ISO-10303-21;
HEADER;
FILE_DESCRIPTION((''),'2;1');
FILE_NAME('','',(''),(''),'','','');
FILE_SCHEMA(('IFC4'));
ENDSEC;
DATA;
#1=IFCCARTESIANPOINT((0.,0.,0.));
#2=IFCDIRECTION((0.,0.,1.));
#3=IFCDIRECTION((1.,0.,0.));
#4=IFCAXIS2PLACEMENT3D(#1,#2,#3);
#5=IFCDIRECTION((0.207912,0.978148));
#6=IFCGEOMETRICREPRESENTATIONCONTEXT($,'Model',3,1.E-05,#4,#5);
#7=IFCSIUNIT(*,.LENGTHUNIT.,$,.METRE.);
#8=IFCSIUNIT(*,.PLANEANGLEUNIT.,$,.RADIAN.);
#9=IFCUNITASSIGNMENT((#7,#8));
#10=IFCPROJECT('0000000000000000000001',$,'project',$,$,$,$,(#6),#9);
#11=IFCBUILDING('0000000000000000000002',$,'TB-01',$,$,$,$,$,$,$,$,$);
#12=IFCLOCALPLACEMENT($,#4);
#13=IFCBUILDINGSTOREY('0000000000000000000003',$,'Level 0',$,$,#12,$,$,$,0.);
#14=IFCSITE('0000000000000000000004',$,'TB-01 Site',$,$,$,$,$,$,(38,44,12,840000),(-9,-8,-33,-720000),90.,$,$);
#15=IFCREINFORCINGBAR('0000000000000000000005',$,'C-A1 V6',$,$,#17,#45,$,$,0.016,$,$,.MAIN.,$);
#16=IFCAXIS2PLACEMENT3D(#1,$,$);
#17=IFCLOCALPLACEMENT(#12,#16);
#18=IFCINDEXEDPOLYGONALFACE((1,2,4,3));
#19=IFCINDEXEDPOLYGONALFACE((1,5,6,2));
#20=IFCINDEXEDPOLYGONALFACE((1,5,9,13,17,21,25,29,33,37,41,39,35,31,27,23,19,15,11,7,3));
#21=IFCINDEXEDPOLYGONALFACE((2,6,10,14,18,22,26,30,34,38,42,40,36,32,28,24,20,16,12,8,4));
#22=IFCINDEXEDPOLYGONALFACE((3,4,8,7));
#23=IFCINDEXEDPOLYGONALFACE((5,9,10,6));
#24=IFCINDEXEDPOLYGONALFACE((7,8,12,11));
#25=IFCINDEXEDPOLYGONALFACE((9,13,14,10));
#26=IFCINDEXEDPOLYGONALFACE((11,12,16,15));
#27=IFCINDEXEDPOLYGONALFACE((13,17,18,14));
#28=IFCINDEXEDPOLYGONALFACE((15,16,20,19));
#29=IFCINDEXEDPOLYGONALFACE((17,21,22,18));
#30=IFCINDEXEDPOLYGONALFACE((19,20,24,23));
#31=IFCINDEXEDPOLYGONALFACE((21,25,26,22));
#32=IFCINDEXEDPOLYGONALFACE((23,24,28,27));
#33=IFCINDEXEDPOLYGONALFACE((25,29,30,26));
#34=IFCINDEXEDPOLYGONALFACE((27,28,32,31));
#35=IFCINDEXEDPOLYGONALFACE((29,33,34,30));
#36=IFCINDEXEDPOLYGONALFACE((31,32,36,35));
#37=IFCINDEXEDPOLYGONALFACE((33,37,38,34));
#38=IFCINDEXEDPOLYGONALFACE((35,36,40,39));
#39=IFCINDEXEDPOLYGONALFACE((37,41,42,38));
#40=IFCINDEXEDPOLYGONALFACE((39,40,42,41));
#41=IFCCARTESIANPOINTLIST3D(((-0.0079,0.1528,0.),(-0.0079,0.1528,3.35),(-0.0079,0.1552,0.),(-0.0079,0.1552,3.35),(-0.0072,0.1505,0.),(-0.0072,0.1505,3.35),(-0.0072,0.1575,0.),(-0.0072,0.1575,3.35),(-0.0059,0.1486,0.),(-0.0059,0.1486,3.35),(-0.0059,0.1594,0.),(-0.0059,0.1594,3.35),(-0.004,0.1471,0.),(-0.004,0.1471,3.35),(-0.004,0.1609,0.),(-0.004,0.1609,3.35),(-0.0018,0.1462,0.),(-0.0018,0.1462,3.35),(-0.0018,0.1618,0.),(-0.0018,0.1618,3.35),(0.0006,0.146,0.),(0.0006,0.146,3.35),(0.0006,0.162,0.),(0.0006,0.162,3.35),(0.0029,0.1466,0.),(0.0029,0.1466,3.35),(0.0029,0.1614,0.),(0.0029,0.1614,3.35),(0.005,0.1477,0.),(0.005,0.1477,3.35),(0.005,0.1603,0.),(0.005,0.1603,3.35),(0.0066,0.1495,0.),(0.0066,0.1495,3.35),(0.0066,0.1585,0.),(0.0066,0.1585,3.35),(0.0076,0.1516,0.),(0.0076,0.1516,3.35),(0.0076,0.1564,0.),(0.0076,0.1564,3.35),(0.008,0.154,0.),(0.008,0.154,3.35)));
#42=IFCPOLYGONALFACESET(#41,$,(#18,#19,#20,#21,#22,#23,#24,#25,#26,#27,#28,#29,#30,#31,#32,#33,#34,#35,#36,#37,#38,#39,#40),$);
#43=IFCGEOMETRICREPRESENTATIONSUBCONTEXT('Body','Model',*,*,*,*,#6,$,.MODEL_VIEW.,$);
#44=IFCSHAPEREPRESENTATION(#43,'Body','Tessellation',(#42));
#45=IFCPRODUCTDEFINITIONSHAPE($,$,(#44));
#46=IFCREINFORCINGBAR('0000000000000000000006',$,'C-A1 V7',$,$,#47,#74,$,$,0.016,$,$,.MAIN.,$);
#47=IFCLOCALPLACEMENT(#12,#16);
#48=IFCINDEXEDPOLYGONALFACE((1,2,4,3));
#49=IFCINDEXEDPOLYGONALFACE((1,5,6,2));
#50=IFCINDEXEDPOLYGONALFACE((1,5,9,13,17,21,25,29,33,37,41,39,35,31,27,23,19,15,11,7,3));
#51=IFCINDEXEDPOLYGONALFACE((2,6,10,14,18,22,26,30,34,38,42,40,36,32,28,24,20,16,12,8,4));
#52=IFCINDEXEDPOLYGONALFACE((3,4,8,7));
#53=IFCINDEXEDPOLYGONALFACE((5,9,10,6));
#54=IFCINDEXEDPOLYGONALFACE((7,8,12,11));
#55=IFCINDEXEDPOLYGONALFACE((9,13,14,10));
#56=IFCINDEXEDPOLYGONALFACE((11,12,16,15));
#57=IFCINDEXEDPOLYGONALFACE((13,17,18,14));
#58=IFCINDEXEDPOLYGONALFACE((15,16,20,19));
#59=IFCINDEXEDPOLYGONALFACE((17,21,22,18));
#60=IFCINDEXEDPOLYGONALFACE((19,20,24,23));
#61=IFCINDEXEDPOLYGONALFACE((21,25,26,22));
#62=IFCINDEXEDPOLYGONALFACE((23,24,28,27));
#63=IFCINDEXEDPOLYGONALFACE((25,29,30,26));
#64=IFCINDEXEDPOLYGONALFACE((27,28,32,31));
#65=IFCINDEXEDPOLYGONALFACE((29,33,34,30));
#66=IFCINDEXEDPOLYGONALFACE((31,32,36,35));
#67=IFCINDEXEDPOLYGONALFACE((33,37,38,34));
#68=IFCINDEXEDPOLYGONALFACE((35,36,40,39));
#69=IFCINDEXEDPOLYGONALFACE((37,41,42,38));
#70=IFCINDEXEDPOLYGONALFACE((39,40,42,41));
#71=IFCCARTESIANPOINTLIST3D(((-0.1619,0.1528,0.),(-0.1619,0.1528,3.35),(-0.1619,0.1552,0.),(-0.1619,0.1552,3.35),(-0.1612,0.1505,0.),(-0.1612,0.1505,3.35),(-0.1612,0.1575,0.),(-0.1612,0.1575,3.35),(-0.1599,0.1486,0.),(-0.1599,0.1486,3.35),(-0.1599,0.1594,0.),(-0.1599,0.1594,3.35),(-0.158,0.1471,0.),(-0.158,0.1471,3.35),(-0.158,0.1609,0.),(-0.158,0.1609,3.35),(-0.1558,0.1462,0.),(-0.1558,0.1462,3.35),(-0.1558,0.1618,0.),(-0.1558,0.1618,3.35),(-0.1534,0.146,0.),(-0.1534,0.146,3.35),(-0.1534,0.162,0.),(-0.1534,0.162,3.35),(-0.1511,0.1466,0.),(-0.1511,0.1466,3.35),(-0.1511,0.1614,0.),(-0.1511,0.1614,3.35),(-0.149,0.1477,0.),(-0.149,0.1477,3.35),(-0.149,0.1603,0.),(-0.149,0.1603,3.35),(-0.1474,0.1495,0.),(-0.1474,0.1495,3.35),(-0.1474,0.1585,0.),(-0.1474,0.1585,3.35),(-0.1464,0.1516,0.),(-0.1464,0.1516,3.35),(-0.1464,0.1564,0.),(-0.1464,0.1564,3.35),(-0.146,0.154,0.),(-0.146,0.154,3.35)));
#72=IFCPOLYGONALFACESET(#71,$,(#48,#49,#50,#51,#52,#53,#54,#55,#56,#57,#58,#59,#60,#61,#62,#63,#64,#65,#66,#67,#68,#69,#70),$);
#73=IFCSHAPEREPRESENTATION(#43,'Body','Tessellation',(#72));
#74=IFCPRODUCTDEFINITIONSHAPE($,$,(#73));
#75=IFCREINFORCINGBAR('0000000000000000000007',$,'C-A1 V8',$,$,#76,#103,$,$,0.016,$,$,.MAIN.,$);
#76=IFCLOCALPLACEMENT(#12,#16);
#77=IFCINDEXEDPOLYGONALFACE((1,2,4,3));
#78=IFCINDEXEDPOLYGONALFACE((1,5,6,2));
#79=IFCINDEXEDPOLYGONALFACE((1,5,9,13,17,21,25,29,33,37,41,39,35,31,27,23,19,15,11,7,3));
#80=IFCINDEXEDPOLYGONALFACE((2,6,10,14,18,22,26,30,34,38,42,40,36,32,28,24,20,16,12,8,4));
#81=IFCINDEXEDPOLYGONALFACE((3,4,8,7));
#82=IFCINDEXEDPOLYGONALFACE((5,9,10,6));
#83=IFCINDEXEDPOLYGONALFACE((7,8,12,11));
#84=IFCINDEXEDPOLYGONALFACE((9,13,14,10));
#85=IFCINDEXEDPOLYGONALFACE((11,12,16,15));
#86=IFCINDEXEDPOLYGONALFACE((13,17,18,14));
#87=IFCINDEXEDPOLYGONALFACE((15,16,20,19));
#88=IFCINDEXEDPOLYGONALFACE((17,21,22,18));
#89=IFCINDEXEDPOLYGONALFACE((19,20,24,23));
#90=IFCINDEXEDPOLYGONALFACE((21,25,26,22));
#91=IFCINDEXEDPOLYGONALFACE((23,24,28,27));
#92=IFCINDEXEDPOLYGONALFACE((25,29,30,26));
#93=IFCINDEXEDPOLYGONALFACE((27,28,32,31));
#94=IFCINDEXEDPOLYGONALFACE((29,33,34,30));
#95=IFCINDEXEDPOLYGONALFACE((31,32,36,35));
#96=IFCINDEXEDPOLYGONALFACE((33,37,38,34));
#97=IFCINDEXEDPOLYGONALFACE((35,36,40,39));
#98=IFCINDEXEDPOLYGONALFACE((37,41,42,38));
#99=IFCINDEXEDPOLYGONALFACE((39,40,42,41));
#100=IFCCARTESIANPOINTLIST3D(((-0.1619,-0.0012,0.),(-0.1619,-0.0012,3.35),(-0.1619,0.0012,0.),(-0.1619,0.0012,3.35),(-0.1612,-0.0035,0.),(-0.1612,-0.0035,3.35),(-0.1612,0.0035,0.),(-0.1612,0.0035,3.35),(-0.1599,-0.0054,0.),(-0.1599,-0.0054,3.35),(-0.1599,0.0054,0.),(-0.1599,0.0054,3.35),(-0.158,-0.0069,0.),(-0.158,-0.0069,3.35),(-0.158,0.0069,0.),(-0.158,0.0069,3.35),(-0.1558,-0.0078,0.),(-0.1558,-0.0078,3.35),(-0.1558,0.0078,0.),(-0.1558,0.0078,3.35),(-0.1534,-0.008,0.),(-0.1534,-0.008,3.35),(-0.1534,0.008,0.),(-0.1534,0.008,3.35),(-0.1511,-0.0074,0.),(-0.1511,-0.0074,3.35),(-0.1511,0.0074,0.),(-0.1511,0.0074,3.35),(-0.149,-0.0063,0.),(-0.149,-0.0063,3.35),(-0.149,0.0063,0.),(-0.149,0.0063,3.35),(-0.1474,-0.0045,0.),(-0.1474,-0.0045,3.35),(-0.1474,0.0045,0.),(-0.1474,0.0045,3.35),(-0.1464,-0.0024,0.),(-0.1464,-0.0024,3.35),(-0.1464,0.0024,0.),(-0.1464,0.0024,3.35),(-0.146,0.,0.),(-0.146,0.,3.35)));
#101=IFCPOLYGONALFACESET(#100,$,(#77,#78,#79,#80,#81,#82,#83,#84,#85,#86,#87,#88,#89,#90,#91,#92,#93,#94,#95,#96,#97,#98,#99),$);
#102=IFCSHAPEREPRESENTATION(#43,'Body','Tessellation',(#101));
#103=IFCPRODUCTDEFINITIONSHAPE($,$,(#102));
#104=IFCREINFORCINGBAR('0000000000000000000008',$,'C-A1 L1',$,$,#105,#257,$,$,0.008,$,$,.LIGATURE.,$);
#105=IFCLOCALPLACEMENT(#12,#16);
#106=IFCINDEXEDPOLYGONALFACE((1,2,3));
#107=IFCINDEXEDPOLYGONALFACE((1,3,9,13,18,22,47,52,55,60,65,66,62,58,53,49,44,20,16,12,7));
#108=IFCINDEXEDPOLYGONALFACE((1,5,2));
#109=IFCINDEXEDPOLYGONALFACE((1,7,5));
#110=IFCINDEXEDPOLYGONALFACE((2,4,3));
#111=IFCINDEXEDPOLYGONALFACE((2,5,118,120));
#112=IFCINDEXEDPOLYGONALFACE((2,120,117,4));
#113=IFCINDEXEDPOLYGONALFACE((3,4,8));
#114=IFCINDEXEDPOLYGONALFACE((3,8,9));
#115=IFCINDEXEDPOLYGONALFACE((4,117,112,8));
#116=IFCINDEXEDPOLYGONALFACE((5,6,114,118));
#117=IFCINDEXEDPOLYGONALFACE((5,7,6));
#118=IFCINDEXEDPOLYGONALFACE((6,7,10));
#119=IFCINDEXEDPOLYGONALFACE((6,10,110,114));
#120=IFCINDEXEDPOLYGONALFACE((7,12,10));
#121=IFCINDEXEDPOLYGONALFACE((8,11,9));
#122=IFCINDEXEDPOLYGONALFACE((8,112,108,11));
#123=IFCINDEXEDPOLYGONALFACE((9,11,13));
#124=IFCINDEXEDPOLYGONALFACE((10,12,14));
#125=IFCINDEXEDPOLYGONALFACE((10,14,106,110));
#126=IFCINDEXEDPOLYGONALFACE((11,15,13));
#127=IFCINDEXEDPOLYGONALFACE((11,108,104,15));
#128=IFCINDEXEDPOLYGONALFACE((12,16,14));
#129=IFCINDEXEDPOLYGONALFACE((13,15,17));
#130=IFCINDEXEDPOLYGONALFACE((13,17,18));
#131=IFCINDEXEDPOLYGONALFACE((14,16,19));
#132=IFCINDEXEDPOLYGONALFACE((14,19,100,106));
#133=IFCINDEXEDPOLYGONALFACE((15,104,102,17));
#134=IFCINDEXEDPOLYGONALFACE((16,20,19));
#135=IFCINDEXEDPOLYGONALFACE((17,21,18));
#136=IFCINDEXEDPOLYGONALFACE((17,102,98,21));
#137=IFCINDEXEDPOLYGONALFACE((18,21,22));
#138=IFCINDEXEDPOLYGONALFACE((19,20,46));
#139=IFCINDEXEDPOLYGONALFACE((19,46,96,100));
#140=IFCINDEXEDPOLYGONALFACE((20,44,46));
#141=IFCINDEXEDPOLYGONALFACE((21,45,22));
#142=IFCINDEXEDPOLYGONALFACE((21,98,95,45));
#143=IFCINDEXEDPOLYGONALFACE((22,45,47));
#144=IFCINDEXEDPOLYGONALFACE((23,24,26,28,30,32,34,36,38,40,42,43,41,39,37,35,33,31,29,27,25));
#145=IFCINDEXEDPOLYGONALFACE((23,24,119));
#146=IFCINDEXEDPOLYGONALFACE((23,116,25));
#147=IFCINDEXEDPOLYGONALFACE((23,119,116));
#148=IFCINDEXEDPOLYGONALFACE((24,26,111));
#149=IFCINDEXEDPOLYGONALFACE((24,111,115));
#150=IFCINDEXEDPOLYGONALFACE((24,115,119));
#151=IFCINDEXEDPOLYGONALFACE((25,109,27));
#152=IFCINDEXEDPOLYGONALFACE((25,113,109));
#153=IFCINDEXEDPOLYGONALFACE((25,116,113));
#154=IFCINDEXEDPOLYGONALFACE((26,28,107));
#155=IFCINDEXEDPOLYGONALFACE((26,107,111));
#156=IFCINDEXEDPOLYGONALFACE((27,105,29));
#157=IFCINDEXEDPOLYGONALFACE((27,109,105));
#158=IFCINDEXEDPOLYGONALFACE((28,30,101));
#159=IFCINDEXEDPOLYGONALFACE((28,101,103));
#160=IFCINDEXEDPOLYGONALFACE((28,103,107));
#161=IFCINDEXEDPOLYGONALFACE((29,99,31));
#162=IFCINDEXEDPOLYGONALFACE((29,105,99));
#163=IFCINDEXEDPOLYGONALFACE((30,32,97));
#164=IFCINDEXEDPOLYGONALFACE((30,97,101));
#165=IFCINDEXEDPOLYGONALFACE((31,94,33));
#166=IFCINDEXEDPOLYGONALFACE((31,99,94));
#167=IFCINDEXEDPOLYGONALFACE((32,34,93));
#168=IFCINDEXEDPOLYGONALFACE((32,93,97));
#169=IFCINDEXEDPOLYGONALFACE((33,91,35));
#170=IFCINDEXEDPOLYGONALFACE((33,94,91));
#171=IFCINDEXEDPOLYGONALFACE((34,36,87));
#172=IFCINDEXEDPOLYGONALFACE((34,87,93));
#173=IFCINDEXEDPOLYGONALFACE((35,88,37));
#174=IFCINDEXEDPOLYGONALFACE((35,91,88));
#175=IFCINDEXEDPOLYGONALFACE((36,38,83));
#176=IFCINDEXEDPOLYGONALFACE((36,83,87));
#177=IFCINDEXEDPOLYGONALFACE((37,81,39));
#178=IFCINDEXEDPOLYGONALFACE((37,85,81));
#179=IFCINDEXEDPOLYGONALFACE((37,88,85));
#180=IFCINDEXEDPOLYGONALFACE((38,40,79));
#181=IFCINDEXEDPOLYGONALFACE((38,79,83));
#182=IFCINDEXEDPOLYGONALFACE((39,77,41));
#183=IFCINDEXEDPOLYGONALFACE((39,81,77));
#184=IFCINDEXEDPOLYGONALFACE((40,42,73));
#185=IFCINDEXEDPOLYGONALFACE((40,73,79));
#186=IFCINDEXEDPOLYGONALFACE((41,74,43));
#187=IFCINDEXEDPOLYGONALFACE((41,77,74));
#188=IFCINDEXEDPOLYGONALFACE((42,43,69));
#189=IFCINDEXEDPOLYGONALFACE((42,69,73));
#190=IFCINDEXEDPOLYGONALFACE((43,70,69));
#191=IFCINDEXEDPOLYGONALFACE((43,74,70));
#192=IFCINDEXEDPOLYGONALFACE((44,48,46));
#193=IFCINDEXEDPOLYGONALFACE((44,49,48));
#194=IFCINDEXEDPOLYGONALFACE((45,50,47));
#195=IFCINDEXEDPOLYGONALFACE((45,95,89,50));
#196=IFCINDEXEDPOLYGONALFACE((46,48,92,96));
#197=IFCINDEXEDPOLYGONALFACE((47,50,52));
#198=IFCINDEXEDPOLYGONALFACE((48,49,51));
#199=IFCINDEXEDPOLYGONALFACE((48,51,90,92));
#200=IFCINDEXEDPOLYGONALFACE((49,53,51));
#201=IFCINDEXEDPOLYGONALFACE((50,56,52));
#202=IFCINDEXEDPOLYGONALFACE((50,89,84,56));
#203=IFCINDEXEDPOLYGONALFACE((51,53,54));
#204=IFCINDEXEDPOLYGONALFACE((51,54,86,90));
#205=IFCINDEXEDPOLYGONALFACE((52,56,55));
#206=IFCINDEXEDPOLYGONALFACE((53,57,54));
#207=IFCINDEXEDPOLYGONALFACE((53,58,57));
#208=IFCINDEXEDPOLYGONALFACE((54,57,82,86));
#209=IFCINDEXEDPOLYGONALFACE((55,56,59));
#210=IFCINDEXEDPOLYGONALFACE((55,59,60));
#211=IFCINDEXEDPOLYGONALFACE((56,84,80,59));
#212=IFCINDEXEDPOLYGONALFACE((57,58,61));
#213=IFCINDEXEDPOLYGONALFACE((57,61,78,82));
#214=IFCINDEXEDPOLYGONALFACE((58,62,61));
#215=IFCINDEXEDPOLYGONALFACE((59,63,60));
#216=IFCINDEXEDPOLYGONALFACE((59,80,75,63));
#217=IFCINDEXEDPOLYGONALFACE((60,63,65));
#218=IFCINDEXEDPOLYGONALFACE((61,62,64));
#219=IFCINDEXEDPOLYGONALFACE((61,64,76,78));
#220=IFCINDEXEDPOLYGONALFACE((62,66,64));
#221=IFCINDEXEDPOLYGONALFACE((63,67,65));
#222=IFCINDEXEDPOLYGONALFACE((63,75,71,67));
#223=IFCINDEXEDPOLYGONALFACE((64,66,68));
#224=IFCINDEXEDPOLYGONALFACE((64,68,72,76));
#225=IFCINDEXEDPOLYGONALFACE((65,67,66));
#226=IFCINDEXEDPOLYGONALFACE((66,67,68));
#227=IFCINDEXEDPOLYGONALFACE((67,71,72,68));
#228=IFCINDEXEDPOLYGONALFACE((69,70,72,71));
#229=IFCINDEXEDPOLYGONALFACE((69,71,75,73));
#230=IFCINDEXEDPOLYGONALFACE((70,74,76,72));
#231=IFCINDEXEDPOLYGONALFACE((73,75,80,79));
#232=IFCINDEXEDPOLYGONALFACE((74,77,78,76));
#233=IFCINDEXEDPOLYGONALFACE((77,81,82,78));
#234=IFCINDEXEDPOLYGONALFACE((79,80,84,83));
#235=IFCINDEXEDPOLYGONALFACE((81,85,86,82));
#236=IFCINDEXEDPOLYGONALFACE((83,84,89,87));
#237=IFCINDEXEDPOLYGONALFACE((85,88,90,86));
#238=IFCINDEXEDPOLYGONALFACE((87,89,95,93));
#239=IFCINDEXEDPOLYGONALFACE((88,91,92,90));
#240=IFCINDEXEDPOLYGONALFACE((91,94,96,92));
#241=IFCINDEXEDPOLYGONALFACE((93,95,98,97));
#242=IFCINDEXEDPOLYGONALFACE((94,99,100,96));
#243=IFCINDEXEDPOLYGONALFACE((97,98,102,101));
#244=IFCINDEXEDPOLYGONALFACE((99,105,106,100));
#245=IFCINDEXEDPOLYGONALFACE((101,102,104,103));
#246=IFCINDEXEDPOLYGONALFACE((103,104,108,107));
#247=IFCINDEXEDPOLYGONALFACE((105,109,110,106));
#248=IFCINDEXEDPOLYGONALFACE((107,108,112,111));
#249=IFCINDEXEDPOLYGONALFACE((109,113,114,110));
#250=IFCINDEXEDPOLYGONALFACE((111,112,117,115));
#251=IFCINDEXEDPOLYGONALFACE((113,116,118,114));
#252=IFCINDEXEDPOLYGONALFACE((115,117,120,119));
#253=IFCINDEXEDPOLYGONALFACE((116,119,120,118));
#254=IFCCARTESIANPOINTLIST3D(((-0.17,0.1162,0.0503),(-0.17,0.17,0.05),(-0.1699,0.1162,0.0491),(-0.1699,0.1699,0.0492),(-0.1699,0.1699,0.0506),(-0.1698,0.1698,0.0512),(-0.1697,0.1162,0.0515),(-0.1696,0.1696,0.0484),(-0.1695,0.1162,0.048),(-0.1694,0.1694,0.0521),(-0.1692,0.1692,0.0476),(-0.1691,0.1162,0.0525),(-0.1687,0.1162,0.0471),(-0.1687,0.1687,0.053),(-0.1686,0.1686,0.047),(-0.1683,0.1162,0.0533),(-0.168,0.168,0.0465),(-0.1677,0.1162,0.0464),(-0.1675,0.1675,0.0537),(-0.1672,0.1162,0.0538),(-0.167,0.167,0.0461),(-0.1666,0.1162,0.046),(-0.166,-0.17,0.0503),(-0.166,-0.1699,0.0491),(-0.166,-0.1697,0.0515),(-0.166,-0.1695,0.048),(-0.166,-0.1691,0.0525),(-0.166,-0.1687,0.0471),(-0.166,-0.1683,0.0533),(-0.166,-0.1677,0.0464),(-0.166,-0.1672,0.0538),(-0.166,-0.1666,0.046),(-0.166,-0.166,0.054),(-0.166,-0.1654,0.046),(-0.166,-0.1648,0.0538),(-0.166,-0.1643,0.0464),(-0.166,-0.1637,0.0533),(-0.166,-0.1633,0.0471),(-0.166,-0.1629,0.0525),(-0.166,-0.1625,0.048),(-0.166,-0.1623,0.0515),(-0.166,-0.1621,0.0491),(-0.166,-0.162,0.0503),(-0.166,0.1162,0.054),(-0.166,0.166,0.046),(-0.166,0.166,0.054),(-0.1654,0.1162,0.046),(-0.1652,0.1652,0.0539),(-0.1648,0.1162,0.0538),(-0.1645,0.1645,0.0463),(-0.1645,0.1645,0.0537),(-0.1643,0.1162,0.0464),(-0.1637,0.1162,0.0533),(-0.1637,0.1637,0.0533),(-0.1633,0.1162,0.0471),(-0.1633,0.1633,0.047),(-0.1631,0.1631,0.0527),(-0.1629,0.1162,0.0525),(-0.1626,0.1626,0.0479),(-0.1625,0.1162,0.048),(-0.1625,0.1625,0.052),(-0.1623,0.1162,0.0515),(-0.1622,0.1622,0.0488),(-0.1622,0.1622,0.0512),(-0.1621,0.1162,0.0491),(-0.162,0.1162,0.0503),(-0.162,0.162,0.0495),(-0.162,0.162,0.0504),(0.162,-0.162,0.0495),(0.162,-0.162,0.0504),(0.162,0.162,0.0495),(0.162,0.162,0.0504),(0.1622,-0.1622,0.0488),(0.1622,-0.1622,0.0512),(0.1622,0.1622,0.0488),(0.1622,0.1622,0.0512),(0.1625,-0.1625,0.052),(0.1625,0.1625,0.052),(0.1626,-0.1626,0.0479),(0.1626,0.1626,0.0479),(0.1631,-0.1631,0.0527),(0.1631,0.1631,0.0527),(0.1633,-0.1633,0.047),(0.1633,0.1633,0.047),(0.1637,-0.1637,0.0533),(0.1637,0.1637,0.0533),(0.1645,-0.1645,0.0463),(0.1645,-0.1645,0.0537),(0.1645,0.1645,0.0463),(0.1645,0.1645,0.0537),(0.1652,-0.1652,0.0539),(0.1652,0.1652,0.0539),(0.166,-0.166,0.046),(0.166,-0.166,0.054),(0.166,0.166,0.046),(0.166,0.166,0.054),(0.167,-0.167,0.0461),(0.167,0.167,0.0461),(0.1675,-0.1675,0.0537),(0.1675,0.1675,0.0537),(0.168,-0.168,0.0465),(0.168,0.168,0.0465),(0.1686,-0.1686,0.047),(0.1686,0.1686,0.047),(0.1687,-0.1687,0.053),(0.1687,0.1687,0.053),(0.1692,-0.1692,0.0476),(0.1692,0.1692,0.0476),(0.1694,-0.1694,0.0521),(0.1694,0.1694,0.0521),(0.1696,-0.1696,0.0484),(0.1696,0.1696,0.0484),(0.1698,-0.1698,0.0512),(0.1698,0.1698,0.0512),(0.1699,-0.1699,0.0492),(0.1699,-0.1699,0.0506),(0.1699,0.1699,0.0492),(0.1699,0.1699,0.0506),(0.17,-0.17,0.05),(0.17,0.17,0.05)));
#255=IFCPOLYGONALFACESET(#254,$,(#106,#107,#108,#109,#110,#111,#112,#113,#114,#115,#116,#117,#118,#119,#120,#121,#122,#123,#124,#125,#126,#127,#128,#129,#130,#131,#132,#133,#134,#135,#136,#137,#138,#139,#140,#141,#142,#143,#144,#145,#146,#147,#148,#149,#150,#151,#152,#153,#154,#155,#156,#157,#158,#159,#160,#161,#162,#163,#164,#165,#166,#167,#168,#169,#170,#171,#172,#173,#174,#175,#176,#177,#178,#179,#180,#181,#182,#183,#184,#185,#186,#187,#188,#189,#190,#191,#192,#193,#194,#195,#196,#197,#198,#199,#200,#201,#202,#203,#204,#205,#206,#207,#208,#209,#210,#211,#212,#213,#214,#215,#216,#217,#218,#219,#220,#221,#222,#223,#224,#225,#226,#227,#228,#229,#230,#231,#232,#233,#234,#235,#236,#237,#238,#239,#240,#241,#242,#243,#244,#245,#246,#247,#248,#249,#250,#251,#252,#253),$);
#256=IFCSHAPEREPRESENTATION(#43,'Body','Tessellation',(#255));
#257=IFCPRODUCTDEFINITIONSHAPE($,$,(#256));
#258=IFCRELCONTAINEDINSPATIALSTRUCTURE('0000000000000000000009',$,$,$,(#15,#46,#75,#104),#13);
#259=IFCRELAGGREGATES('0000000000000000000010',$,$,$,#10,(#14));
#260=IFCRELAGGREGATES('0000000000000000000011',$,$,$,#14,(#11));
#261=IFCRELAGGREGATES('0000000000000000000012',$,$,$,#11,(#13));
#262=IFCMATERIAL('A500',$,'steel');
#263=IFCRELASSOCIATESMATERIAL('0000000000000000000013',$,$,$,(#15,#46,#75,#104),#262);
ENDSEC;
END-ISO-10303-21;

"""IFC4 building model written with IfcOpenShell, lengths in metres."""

from ifc_helpers import new_model, entity, si_unit, direction, origin_with_axes, place, context, subcontext, project, spatial, material, element, save


model = new_model("IFC4")

# Units and contexts
model_context = context("Model", 3, precision=1e-05, world=origin_with_axes(), true_north=direction((0.207912, 0.978148)))
body_context = subcontext(model_context, "Body", "Model", "MODEL_VIEW")
ifc_project = project(units=[si_unit("LENGTHUNIT", "METRE"), si_unit("PLANEANGLEUNIT", "RADIAN")], contexts=[model_context])

# Site, building, storey
site = spatial("IfcSite", under=ifc_project, Name="TB-01 Site", RefLatitude=(38, 44, 12, 840000), RefLongitude=(-9, -8, -33, -720000), RefElevation=90.0)
building = spatial("IfcBuilding", under=site, Name="TB-01")
storey_placement = place(None, origin_with_axes())
storey = spatial("IfcBuildingStorey", under=building, at=storey_placement, Name="Level 0", Elevation=0.0)

# Reinforcing bars
ifc_material_1 = material(Name="A500", Category="steel")
reinforcing_bar_1_placement = place(storey_placement, origin_with_axes())
element("IfcReinforcingBar", 1, at=reinforcing_bar_1_placement, inside=storey, material=ifc_material_1, Name="C-A1 V6", NominalDiameter=0.016, PredefinedType="MAIN", context=body_context, shape_type="AdvancedSweptSolid", body=[
    entity("IfcSweptDiskSolid", entity("IfcPolyline", [entity("IfcCartesianPoint", [0.0, 0.154, 0.0]), entity("IfcCartesianPoint", [0.0, 0.154, 3.35])]), 0.008),
])
reinforcing_bar_2_placement = place(storey_placement, origin_with_axes())
element("IfcReinforcingBar", 2, at=reinforcing_bar_2_placement, inside=storey, material=ifc_material_1, Name="C-A1 V7", NominalDiameter=0.016, PredefinedType="MAIN", context=body_context, shape_type="AdvancedSweptSolid", body=[
    entity("IfcSweptDiskSolid", entity("IfcPolyline", [entity("IfcCartesianPoint", [-0.154, 0.154, 0.0]), entity("IfcCartesianPoint", [-0.154, 0.154, 3.35])]), 0.008),
])
reinforcing_bar_3_placement = place(storey_placement, origin_with_axes())
element("IfcReinforcingBar", 3, at=reinforcing_bar_3_placement, inside=storey, material=ifc_material_1, Name="C-A1 V8", NominalDiameter=0.016, PredefinedType="MAIN", context=body_context, shape_type="AdvancedSweptSolid", body=[
    entity("IfcSweptDiskSolid", entity("IfcPolyline", [entity("IfcCartesianPoint", [-0.154, 0.0, 0.0]), entity("IfcCartesianPoint", [-0.154, 0.0, 3.35])]), 0.008),
])
reinforcing_bar_4_placement = place(storey_placement, origin_with_axes())
element("IfcReinforcingBar", 4, at=reinforcing_bar_4_placement, inside=storey, material=ifc_material_1, Name="C-A1 L1", NominalDiameter=0.008, PredefinedType="LIGATURE", context=body_context, shape_type="AdvancedSweptSolid", body=[
    entity("IfcSweptDiskSolid", entity("IfcPolyline", [entity("IfcCartesianPoint", [-0.166, -0.166, 0.05]), entity("IfcCartesianPoint", [0.166, -0.166, 0.05]), entity("IfcCartesianPoint", [0.166, 0.166, 0.05]), entity("IfcCartesianPoint", [-0.166, 0.166, 0.05]), entity("IfcCartesianPoint", [-0.166, 0.1162, 0.05])]), 0.004),
])

save(model, "model.ifc")
